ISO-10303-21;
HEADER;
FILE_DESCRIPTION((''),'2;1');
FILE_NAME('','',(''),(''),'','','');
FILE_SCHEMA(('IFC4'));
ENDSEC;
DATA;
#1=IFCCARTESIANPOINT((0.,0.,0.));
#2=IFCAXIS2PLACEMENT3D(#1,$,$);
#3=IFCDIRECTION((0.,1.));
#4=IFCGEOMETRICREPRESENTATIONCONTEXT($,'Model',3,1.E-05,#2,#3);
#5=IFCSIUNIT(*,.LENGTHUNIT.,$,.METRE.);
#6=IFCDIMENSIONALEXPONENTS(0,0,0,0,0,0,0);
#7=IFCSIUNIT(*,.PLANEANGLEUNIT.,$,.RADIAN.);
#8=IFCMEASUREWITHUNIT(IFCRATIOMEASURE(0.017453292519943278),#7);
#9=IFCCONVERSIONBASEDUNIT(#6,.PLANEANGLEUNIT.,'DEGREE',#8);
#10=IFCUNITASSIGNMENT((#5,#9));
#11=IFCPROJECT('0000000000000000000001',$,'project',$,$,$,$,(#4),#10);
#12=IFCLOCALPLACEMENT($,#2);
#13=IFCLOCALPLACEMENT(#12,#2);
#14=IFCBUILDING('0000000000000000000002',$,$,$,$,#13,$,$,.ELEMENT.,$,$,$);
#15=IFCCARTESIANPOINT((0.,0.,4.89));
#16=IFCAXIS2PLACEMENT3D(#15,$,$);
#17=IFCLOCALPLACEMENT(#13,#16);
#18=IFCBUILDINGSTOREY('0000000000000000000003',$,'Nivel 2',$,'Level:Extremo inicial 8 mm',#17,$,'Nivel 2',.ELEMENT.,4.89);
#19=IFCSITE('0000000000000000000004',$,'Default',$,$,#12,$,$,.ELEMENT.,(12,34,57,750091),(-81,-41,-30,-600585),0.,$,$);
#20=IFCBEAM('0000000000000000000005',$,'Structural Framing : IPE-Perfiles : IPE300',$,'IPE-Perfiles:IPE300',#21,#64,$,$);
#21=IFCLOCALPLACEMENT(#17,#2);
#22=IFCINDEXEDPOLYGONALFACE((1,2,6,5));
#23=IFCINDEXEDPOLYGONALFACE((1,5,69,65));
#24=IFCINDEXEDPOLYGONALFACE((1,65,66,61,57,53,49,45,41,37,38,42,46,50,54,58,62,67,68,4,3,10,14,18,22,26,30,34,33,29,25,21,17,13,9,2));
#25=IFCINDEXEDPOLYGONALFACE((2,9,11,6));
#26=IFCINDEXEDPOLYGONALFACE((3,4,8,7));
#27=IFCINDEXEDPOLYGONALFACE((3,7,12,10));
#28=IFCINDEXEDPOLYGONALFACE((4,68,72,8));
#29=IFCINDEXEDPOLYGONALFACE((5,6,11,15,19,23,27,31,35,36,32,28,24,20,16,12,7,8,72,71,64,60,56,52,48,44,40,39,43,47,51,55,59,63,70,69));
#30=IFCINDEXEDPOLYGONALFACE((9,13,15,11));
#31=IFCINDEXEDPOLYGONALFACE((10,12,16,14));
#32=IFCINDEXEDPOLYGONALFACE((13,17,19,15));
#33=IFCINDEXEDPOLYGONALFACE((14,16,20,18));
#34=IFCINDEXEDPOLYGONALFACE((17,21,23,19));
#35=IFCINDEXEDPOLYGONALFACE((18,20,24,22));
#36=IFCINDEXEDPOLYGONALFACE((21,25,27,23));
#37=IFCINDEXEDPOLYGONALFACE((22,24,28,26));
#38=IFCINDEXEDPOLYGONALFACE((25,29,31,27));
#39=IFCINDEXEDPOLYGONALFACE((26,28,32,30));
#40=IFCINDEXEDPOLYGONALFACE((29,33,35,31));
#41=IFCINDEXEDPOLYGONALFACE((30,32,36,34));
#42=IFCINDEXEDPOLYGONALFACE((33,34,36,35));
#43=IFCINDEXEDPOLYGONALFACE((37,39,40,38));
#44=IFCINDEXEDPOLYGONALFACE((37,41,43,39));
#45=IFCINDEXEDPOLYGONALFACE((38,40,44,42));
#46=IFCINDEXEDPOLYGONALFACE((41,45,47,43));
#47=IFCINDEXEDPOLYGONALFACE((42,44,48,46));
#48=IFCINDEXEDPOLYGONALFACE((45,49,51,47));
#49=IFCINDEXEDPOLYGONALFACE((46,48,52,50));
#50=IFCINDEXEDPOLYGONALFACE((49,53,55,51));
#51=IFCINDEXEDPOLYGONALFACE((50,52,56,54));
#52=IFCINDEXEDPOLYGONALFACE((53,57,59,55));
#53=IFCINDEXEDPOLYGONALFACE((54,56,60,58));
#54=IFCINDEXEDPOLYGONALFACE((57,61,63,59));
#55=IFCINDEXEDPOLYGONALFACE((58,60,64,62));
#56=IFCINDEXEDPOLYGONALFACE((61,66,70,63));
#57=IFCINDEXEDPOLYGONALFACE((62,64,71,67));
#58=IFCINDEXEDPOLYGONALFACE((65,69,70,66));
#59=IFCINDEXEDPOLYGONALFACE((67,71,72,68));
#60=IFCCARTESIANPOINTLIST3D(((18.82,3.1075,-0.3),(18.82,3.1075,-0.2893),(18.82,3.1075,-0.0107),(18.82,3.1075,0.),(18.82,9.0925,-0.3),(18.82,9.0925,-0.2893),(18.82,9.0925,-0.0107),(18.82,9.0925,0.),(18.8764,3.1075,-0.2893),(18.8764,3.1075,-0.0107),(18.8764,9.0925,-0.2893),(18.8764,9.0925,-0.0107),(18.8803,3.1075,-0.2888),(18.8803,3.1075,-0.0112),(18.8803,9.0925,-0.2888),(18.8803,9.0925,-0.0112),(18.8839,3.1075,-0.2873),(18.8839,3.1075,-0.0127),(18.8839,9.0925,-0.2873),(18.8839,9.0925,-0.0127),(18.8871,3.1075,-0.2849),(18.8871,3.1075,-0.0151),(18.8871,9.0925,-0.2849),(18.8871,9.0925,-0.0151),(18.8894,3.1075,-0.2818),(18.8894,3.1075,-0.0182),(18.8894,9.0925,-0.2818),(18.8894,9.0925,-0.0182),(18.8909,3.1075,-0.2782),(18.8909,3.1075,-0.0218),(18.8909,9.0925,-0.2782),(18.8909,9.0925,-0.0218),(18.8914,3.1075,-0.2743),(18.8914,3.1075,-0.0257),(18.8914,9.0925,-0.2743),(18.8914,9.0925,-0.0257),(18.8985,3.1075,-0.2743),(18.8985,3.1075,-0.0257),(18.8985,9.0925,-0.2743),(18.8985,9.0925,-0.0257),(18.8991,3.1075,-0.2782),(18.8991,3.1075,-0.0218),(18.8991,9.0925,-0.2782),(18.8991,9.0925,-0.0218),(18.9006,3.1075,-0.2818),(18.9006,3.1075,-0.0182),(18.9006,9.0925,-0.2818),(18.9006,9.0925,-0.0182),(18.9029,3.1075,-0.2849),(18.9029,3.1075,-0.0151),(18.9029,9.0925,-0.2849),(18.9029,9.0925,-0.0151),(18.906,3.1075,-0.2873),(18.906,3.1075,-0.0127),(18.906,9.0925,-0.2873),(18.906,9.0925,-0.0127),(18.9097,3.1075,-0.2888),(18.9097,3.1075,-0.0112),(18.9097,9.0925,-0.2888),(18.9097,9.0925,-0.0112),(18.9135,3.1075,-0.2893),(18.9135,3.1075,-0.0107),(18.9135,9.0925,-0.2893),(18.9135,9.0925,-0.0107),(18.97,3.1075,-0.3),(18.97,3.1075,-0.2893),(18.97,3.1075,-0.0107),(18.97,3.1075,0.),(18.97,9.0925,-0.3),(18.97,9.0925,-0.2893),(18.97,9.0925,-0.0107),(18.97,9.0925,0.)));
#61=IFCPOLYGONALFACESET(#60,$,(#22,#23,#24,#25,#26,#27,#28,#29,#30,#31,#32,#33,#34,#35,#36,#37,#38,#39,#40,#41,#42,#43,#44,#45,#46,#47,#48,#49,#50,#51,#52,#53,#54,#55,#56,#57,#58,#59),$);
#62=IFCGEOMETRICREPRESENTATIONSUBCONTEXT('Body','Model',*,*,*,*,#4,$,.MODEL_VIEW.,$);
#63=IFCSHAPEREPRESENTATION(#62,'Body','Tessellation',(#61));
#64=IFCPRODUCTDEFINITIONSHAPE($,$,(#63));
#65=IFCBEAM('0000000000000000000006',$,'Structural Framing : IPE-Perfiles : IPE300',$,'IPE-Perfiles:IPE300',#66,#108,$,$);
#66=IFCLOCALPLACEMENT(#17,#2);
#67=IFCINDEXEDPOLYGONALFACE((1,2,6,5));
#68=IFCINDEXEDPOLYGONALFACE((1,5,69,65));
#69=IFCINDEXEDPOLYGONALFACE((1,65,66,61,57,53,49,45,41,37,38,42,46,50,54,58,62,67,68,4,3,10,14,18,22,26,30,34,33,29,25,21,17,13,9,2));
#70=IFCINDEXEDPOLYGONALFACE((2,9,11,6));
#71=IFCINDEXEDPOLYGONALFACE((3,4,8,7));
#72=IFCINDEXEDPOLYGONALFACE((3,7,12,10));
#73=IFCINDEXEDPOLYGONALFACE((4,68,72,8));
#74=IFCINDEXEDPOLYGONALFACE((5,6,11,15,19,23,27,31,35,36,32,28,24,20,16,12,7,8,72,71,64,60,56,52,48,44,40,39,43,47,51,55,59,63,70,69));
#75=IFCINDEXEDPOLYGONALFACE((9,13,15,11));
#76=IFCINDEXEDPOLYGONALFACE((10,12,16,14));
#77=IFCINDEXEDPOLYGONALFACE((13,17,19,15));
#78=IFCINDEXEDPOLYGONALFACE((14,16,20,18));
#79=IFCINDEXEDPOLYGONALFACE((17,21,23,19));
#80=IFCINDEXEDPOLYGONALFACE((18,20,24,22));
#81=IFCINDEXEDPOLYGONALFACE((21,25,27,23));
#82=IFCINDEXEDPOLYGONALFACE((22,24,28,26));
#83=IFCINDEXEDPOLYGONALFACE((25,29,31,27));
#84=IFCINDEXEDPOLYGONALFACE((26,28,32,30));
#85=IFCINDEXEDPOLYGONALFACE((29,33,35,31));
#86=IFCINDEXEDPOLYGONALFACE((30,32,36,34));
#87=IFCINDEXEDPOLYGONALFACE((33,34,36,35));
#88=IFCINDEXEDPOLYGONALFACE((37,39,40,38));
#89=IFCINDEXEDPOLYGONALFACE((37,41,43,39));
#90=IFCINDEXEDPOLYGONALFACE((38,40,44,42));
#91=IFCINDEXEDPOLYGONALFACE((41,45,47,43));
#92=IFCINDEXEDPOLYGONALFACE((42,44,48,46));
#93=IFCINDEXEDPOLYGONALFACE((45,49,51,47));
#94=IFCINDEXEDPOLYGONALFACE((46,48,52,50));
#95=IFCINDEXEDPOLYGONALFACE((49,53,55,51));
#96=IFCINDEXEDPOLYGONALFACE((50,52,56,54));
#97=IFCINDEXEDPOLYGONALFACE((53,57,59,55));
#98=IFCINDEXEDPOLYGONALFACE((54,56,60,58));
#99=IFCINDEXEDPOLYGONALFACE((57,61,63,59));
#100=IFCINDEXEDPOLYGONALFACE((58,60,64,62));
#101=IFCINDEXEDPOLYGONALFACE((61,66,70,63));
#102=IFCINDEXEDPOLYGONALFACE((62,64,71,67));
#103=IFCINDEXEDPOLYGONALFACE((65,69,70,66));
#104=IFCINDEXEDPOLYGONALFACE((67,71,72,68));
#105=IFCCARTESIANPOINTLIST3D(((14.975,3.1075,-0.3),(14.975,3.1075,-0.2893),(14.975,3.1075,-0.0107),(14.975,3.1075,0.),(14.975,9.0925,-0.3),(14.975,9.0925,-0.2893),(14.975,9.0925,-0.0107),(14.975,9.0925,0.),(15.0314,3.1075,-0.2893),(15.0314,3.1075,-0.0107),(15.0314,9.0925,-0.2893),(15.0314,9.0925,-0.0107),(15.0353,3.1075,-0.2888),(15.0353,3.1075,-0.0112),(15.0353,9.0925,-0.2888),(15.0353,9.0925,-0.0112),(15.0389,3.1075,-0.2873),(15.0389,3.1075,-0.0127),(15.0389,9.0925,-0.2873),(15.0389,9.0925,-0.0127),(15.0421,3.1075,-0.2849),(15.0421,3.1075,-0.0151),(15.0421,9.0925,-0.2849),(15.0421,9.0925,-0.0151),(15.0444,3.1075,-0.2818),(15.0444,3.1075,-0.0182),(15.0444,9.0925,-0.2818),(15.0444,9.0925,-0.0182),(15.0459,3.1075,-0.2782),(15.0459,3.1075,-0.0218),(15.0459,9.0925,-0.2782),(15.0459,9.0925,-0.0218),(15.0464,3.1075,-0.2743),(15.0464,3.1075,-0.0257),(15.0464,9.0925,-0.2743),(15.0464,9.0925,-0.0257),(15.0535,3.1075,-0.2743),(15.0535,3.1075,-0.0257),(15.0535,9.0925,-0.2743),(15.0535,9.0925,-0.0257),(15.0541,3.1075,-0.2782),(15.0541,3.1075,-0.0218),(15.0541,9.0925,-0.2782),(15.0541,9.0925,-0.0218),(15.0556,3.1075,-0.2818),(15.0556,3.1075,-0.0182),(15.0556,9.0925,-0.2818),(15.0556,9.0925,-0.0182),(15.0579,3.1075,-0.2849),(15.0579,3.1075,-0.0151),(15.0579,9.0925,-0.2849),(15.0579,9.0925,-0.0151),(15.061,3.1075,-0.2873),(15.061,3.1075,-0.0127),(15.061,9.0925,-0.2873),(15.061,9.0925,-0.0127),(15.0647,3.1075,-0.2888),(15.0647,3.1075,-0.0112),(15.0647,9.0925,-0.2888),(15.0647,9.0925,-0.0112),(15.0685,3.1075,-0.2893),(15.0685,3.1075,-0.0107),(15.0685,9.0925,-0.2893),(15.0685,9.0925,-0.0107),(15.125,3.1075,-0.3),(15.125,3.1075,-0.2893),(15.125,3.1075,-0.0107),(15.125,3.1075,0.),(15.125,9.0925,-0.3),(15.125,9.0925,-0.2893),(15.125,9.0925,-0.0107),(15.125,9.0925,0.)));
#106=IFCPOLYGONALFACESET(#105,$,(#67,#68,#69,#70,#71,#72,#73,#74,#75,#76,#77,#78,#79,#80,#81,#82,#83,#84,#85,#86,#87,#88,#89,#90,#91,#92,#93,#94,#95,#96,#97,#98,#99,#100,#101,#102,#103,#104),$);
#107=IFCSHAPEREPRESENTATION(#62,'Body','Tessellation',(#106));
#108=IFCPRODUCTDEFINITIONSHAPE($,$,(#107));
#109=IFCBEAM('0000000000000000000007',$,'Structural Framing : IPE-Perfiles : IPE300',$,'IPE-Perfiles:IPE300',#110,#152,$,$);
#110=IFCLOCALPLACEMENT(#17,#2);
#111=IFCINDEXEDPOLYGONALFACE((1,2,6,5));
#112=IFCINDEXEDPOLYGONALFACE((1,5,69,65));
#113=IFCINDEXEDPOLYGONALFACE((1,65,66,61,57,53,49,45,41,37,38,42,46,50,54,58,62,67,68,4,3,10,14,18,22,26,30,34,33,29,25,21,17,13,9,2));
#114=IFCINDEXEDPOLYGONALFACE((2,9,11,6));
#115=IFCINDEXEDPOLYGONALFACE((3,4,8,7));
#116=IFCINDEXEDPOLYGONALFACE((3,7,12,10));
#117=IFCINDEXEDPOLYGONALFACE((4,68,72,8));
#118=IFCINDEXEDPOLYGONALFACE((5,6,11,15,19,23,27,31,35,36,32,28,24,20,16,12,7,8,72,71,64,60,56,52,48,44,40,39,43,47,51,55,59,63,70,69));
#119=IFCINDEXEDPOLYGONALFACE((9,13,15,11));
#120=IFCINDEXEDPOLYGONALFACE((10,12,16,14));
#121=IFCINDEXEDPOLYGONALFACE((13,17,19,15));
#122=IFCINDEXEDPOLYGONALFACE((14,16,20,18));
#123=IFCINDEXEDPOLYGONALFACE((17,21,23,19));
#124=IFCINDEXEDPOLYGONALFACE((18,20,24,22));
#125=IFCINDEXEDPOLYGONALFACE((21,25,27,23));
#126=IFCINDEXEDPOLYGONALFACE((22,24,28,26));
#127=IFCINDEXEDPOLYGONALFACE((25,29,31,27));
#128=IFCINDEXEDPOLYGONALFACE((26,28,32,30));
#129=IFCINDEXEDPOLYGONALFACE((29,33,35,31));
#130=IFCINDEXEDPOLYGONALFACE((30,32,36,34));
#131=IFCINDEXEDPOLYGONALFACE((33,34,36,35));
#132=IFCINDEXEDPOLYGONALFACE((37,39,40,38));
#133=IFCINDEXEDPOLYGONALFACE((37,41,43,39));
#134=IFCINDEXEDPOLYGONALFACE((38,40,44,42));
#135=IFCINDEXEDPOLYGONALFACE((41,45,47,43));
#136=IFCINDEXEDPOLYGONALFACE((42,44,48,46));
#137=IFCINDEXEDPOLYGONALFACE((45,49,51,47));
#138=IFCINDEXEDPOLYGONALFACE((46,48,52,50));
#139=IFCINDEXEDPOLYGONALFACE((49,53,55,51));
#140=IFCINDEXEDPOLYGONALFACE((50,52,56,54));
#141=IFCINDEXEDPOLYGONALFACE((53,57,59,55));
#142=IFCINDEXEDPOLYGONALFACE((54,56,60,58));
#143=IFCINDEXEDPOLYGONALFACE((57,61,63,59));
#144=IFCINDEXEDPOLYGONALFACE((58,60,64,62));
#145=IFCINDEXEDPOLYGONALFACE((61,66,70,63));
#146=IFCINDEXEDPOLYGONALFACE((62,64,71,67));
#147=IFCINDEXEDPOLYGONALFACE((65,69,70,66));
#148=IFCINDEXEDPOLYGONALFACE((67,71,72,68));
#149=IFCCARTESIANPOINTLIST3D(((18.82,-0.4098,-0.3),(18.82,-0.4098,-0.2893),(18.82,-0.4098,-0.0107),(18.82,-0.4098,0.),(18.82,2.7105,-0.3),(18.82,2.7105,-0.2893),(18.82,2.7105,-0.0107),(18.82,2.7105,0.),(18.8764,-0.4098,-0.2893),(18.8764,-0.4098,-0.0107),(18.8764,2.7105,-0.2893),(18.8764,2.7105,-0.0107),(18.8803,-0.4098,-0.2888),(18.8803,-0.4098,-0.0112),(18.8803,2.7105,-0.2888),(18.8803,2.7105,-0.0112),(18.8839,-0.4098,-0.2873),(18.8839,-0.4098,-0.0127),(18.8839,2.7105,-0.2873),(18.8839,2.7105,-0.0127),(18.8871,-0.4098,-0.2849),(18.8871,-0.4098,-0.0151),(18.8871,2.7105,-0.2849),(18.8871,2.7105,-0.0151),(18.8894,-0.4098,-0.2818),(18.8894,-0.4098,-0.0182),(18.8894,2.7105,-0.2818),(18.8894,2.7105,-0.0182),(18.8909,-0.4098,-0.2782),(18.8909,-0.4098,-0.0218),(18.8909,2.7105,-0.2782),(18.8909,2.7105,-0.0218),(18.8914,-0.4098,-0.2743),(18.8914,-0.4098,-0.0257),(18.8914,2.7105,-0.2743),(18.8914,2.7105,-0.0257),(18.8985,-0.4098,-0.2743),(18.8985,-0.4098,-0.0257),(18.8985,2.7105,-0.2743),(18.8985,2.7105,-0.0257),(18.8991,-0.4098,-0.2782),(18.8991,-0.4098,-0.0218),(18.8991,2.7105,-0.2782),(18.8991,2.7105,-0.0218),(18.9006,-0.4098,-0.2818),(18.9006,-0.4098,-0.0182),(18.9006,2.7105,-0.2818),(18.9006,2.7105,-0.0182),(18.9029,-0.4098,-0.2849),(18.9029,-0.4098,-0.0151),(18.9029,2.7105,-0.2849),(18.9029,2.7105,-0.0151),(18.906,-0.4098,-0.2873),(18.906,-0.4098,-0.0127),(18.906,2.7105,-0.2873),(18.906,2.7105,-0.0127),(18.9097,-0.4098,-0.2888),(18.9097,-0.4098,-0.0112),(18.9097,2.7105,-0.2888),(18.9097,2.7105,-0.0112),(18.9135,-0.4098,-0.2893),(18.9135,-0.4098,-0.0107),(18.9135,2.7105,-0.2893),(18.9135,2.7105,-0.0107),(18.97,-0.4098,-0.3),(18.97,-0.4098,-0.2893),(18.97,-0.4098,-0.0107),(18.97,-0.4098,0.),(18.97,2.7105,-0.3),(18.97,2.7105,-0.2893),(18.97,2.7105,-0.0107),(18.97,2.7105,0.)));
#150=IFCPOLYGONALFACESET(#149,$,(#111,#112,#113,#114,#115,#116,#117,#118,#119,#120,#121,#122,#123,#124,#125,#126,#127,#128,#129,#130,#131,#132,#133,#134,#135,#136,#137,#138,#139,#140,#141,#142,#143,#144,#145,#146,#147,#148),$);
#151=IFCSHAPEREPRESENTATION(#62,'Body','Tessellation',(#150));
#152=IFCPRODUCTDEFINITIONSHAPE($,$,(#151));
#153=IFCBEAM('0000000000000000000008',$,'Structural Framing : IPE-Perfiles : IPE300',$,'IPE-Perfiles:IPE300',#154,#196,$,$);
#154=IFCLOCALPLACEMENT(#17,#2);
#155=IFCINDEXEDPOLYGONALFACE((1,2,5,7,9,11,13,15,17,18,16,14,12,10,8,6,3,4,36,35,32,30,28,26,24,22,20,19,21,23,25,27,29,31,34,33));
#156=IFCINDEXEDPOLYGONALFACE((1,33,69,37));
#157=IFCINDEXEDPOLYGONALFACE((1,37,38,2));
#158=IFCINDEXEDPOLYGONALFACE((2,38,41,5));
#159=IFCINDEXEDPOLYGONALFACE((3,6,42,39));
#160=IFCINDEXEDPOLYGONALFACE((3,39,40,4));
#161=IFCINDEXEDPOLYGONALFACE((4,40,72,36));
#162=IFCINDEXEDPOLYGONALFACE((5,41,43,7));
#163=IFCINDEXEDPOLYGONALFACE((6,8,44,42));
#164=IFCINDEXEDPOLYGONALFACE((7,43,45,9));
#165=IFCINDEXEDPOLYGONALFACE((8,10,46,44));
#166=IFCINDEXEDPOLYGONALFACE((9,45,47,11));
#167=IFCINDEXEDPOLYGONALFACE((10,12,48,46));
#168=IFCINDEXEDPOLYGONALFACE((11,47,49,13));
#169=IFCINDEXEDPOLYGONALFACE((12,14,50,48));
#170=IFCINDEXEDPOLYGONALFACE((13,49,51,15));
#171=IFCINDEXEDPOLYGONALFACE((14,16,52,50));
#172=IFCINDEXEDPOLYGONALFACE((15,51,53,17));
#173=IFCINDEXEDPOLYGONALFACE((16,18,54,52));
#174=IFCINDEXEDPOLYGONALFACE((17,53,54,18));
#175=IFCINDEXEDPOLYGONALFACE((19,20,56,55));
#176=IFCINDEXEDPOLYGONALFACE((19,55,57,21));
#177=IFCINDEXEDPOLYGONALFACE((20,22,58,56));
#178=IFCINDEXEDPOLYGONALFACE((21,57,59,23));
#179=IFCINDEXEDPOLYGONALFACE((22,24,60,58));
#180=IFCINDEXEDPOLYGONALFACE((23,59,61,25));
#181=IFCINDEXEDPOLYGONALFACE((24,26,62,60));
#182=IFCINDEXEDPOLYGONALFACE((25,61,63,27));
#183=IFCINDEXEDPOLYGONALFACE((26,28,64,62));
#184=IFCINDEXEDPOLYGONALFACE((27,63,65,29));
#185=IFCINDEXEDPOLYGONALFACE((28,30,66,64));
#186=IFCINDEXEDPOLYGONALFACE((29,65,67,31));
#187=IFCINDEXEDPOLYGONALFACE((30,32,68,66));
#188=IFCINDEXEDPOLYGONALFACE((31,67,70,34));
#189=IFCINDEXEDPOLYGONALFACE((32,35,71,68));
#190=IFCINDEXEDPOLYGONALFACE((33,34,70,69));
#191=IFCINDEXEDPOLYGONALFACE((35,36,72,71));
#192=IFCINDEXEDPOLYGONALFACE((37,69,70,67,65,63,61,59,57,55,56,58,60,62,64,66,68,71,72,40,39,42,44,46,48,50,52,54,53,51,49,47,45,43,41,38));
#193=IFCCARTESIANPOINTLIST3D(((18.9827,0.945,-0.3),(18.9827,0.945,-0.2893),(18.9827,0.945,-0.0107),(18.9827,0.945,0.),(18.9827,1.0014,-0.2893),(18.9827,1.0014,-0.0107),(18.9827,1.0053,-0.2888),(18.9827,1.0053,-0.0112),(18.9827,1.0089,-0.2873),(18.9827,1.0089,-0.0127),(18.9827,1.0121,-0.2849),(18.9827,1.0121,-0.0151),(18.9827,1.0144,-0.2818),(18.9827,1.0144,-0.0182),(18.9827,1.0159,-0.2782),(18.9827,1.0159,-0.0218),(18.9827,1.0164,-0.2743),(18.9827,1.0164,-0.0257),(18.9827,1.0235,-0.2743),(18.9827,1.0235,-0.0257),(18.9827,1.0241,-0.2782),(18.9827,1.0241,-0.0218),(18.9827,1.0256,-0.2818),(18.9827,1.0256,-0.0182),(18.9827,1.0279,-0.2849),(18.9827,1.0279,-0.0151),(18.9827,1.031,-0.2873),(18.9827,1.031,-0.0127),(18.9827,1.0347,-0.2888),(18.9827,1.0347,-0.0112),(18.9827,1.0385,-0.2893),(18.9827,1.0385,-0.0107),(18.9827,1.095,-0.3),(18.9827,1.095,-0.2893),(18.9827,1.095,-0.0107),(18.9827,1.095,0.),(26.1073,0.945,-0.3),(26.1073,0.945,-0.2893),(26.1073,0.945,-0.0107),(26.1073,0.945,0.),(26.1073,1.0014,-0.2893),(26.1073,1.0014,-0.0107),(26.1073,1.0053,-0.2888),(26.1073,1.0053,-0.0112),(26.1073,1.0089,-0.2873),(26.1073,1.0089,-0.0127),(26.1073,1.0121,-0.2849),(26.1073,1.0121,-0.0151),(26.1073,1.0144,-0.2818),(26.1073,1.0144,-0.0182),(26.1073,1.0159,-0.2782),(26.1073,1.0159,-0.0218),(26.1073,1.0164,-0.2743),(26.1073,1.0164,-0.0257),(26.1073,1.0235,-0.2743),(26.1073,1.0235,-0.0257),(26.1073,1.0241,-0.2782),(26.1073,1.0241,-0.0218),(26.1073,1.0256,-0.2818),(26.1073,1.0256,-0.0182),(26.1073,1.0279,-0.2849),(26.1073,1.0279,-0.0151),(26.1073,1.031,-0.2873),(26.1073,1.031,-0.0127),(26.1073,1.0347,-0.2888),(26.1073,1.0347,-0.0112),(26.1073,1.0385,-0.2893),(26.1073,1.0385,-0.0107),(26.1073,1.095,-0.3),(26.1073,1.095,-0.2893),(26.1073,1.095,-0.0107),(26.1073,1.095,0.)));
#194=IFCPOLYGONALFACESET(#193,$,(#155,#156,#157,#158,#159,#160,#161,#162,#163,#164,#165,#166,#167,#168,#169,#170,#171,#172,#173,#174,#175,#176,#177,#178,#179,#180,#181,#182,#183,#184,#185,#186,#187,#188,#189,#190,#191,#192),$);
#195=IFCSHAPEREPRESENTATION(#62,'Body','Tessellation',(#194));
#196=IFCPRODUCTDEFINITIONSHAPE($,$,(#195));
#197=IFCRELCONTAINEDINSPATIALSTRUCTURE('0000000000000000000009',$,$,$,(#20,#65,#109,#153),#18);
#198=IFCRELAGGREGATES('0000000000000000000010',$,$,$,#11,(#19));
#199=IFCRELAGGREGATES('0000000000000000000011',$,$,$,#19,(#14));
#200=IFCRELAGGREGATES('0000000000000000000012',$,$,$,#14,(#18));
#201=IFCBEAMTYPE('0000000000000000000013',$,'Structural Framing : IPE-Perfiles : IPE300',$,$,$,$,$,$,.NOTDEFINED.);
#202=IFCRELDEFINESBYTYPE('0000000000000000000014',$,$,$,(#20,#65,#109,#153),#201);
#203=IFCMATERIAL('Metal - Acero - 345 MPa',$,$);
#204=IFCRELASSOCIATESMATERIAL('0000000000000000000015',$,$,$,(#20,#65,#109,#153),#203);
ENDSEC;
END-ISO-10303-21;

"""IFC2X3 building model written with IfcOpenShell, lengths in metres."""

from ifc_helpers import new_model, entity, si_unit, converted_unit, direction, frame, frame_2d, origin, place, context, subcontext, project, spatial, i_section, extrude, material, type_object, element, save


model = new_model("IFC2X3")

# Units and contexts
model_context = context("Model", 3, precision=1e-05, world=origin(), true_north=direction((0.0, 1.0)))
body_context = subcontext(model_context, "Body", "Model", "MODEL_VIEW")
ifc_project = project(units=[si_unit("LENGTHUNIT", "METRE"), converted_unit("PLANEANGLEUNIT", "DEGREE", entity("IfcRatioMeasure", 0.017453292519943278), si_unit("PLANEANGLEUNIT", "RADIAN"), dimensions=[0, 0, 0, 0, 0, 0, 0])], contexts=[model_context])

# Site, building, storey
site_placement = place(None, origin())
site = spatial("IfcSite", under=ifc_project, at=site_placement, Name="Default", CompositionType="ELEMENT", RefLatitude=(12, 34, 57, 750091), RefLongitude=(-81, -41, -30, -600585), RefElevation=0.0)
building_placement = place(site_placement, origin())
building = spatial("IfcBuilding", under=site, at=building_placement, CompositionType="ELEMENT")
storey_placement = place(building_placement, frame((0.0, 0.0, 4.89)))
storey = spatial("IfcBuildingStorey", under=building, at=storey_placement, Name="Nivel 2", ObjectType="Level:Extremo inicial 8 mm", LongName="Nivel 2", CompositionType="ELEMENT", Elevation=4.89)

# Shared definitions
ifc_material_1 = material(Name="Metal - Acero - 345 MPa")

# Beams
beam_type_1 = type_object("IfcBeamType", Name="Structural Framing : IPE-Perfiles : IPE300", PredefinedType="NOTDEFINED")
for number, where, z_axis, x_axis, name in (
    (1, (18.895, 3.1075, 0.0), (0.0, 0.0, 1.0), (0.0, 1.0, 0.0), "Structural Framing : IPE-Perfiles : IPE300"),
    (2, (15.05, 3.1075, 0.0), (0.0, 0.0, 1.0), (0.0, 1.0, 0.0), "Structural Framing : IPE-Perfiles : IPE300"),
):
    element("IfcBeam", number, at=place(storey_placement, frame(where, z_axis=z_axis, x_axis=x_axis)), inside=storey, type_object=beam_type_1, material=ifc_material_1, Name=name, ObjectType="IPE-Perfiles:IPE300", context=body_context, shape_type="SweptSolid", body=[
        extrude(i_section(OverallWidth=0.15, OverallDepth=0.3, WebThickness=0.0071, FlangeThickness=0.0107, FilletRadius=0.015, at=frame_2d((0.0, 0.0), x_axis=(0.0, 1.0))), frame((0.0, 0.0, -0.15), z_axis=(1.0, 0.0, 0.0), x_axis=(0.0, 0.0, -1.0)), (0.0, 0.0, 1.0), 5.985),
    ])
beam_1_placement = place(storey_placement, frame((18.895, -0.35, 0.0), z_axis=(0.0, 0.0, 1.0), x_axis=(0.0, 1.0, 0.0)))
element("IfcBeam", 3, at=beam_1_placement, inside=storey, type_object=beam_type_1, material=ifc_material_1, Name="Structural Framing : IPE-Perfiles : IPE300", ObjectType="IPE-Perfiles:IPE300", context=body_context, shape_type="SweptSolid", body=[
    extrude(i_section(OverallWidth=0.15, OverallDepth=0.3, WebThickness=0.0071, FlangeThickness=0.0107, FilletRadius=0.015, at=frame_2d((0.0, 0.0), x_axis=(0.0, 1.0))), frame((-0.0598, 0.0, -0.15), z_axis=(1.0, 0.0, 0.0), x_axis=(0.0, 0.0, -1.0)), (0.0, 0.0, 1.0), 3.1203),
])
beam_2_placement = place(storey_placement, frame((18.895, 1.02, 0.0)))
element("IfcBeam", 4, at=beam_2_placement, inside=storey, type_object=beam_type_1, material=ifc_material_1, Name="Structural Framing : IPE-Perfiles : IPE300", ObjectType="IPE-Perfiles:IPE300", context=body_context, shape_type="SweptSolid", body=[
    extrude(i_section(OverallWidth=0.15, OverallDepth=0.3, WebThickness=0.0071, FlangeThickness=0.0107, FilletRadius=0.015, at=frame_2d((0.0, 0.0), x_axis=(0.0, 1.0))), frame((0.0877, 0.0, -0.15), z_axis=(1.0, 0.0, 0.0), x_axis=(0.0, 0.0, -1.0)), (0.0, 0.0, 1.0), 7.1246),
])

save(model, "model.ifc")
